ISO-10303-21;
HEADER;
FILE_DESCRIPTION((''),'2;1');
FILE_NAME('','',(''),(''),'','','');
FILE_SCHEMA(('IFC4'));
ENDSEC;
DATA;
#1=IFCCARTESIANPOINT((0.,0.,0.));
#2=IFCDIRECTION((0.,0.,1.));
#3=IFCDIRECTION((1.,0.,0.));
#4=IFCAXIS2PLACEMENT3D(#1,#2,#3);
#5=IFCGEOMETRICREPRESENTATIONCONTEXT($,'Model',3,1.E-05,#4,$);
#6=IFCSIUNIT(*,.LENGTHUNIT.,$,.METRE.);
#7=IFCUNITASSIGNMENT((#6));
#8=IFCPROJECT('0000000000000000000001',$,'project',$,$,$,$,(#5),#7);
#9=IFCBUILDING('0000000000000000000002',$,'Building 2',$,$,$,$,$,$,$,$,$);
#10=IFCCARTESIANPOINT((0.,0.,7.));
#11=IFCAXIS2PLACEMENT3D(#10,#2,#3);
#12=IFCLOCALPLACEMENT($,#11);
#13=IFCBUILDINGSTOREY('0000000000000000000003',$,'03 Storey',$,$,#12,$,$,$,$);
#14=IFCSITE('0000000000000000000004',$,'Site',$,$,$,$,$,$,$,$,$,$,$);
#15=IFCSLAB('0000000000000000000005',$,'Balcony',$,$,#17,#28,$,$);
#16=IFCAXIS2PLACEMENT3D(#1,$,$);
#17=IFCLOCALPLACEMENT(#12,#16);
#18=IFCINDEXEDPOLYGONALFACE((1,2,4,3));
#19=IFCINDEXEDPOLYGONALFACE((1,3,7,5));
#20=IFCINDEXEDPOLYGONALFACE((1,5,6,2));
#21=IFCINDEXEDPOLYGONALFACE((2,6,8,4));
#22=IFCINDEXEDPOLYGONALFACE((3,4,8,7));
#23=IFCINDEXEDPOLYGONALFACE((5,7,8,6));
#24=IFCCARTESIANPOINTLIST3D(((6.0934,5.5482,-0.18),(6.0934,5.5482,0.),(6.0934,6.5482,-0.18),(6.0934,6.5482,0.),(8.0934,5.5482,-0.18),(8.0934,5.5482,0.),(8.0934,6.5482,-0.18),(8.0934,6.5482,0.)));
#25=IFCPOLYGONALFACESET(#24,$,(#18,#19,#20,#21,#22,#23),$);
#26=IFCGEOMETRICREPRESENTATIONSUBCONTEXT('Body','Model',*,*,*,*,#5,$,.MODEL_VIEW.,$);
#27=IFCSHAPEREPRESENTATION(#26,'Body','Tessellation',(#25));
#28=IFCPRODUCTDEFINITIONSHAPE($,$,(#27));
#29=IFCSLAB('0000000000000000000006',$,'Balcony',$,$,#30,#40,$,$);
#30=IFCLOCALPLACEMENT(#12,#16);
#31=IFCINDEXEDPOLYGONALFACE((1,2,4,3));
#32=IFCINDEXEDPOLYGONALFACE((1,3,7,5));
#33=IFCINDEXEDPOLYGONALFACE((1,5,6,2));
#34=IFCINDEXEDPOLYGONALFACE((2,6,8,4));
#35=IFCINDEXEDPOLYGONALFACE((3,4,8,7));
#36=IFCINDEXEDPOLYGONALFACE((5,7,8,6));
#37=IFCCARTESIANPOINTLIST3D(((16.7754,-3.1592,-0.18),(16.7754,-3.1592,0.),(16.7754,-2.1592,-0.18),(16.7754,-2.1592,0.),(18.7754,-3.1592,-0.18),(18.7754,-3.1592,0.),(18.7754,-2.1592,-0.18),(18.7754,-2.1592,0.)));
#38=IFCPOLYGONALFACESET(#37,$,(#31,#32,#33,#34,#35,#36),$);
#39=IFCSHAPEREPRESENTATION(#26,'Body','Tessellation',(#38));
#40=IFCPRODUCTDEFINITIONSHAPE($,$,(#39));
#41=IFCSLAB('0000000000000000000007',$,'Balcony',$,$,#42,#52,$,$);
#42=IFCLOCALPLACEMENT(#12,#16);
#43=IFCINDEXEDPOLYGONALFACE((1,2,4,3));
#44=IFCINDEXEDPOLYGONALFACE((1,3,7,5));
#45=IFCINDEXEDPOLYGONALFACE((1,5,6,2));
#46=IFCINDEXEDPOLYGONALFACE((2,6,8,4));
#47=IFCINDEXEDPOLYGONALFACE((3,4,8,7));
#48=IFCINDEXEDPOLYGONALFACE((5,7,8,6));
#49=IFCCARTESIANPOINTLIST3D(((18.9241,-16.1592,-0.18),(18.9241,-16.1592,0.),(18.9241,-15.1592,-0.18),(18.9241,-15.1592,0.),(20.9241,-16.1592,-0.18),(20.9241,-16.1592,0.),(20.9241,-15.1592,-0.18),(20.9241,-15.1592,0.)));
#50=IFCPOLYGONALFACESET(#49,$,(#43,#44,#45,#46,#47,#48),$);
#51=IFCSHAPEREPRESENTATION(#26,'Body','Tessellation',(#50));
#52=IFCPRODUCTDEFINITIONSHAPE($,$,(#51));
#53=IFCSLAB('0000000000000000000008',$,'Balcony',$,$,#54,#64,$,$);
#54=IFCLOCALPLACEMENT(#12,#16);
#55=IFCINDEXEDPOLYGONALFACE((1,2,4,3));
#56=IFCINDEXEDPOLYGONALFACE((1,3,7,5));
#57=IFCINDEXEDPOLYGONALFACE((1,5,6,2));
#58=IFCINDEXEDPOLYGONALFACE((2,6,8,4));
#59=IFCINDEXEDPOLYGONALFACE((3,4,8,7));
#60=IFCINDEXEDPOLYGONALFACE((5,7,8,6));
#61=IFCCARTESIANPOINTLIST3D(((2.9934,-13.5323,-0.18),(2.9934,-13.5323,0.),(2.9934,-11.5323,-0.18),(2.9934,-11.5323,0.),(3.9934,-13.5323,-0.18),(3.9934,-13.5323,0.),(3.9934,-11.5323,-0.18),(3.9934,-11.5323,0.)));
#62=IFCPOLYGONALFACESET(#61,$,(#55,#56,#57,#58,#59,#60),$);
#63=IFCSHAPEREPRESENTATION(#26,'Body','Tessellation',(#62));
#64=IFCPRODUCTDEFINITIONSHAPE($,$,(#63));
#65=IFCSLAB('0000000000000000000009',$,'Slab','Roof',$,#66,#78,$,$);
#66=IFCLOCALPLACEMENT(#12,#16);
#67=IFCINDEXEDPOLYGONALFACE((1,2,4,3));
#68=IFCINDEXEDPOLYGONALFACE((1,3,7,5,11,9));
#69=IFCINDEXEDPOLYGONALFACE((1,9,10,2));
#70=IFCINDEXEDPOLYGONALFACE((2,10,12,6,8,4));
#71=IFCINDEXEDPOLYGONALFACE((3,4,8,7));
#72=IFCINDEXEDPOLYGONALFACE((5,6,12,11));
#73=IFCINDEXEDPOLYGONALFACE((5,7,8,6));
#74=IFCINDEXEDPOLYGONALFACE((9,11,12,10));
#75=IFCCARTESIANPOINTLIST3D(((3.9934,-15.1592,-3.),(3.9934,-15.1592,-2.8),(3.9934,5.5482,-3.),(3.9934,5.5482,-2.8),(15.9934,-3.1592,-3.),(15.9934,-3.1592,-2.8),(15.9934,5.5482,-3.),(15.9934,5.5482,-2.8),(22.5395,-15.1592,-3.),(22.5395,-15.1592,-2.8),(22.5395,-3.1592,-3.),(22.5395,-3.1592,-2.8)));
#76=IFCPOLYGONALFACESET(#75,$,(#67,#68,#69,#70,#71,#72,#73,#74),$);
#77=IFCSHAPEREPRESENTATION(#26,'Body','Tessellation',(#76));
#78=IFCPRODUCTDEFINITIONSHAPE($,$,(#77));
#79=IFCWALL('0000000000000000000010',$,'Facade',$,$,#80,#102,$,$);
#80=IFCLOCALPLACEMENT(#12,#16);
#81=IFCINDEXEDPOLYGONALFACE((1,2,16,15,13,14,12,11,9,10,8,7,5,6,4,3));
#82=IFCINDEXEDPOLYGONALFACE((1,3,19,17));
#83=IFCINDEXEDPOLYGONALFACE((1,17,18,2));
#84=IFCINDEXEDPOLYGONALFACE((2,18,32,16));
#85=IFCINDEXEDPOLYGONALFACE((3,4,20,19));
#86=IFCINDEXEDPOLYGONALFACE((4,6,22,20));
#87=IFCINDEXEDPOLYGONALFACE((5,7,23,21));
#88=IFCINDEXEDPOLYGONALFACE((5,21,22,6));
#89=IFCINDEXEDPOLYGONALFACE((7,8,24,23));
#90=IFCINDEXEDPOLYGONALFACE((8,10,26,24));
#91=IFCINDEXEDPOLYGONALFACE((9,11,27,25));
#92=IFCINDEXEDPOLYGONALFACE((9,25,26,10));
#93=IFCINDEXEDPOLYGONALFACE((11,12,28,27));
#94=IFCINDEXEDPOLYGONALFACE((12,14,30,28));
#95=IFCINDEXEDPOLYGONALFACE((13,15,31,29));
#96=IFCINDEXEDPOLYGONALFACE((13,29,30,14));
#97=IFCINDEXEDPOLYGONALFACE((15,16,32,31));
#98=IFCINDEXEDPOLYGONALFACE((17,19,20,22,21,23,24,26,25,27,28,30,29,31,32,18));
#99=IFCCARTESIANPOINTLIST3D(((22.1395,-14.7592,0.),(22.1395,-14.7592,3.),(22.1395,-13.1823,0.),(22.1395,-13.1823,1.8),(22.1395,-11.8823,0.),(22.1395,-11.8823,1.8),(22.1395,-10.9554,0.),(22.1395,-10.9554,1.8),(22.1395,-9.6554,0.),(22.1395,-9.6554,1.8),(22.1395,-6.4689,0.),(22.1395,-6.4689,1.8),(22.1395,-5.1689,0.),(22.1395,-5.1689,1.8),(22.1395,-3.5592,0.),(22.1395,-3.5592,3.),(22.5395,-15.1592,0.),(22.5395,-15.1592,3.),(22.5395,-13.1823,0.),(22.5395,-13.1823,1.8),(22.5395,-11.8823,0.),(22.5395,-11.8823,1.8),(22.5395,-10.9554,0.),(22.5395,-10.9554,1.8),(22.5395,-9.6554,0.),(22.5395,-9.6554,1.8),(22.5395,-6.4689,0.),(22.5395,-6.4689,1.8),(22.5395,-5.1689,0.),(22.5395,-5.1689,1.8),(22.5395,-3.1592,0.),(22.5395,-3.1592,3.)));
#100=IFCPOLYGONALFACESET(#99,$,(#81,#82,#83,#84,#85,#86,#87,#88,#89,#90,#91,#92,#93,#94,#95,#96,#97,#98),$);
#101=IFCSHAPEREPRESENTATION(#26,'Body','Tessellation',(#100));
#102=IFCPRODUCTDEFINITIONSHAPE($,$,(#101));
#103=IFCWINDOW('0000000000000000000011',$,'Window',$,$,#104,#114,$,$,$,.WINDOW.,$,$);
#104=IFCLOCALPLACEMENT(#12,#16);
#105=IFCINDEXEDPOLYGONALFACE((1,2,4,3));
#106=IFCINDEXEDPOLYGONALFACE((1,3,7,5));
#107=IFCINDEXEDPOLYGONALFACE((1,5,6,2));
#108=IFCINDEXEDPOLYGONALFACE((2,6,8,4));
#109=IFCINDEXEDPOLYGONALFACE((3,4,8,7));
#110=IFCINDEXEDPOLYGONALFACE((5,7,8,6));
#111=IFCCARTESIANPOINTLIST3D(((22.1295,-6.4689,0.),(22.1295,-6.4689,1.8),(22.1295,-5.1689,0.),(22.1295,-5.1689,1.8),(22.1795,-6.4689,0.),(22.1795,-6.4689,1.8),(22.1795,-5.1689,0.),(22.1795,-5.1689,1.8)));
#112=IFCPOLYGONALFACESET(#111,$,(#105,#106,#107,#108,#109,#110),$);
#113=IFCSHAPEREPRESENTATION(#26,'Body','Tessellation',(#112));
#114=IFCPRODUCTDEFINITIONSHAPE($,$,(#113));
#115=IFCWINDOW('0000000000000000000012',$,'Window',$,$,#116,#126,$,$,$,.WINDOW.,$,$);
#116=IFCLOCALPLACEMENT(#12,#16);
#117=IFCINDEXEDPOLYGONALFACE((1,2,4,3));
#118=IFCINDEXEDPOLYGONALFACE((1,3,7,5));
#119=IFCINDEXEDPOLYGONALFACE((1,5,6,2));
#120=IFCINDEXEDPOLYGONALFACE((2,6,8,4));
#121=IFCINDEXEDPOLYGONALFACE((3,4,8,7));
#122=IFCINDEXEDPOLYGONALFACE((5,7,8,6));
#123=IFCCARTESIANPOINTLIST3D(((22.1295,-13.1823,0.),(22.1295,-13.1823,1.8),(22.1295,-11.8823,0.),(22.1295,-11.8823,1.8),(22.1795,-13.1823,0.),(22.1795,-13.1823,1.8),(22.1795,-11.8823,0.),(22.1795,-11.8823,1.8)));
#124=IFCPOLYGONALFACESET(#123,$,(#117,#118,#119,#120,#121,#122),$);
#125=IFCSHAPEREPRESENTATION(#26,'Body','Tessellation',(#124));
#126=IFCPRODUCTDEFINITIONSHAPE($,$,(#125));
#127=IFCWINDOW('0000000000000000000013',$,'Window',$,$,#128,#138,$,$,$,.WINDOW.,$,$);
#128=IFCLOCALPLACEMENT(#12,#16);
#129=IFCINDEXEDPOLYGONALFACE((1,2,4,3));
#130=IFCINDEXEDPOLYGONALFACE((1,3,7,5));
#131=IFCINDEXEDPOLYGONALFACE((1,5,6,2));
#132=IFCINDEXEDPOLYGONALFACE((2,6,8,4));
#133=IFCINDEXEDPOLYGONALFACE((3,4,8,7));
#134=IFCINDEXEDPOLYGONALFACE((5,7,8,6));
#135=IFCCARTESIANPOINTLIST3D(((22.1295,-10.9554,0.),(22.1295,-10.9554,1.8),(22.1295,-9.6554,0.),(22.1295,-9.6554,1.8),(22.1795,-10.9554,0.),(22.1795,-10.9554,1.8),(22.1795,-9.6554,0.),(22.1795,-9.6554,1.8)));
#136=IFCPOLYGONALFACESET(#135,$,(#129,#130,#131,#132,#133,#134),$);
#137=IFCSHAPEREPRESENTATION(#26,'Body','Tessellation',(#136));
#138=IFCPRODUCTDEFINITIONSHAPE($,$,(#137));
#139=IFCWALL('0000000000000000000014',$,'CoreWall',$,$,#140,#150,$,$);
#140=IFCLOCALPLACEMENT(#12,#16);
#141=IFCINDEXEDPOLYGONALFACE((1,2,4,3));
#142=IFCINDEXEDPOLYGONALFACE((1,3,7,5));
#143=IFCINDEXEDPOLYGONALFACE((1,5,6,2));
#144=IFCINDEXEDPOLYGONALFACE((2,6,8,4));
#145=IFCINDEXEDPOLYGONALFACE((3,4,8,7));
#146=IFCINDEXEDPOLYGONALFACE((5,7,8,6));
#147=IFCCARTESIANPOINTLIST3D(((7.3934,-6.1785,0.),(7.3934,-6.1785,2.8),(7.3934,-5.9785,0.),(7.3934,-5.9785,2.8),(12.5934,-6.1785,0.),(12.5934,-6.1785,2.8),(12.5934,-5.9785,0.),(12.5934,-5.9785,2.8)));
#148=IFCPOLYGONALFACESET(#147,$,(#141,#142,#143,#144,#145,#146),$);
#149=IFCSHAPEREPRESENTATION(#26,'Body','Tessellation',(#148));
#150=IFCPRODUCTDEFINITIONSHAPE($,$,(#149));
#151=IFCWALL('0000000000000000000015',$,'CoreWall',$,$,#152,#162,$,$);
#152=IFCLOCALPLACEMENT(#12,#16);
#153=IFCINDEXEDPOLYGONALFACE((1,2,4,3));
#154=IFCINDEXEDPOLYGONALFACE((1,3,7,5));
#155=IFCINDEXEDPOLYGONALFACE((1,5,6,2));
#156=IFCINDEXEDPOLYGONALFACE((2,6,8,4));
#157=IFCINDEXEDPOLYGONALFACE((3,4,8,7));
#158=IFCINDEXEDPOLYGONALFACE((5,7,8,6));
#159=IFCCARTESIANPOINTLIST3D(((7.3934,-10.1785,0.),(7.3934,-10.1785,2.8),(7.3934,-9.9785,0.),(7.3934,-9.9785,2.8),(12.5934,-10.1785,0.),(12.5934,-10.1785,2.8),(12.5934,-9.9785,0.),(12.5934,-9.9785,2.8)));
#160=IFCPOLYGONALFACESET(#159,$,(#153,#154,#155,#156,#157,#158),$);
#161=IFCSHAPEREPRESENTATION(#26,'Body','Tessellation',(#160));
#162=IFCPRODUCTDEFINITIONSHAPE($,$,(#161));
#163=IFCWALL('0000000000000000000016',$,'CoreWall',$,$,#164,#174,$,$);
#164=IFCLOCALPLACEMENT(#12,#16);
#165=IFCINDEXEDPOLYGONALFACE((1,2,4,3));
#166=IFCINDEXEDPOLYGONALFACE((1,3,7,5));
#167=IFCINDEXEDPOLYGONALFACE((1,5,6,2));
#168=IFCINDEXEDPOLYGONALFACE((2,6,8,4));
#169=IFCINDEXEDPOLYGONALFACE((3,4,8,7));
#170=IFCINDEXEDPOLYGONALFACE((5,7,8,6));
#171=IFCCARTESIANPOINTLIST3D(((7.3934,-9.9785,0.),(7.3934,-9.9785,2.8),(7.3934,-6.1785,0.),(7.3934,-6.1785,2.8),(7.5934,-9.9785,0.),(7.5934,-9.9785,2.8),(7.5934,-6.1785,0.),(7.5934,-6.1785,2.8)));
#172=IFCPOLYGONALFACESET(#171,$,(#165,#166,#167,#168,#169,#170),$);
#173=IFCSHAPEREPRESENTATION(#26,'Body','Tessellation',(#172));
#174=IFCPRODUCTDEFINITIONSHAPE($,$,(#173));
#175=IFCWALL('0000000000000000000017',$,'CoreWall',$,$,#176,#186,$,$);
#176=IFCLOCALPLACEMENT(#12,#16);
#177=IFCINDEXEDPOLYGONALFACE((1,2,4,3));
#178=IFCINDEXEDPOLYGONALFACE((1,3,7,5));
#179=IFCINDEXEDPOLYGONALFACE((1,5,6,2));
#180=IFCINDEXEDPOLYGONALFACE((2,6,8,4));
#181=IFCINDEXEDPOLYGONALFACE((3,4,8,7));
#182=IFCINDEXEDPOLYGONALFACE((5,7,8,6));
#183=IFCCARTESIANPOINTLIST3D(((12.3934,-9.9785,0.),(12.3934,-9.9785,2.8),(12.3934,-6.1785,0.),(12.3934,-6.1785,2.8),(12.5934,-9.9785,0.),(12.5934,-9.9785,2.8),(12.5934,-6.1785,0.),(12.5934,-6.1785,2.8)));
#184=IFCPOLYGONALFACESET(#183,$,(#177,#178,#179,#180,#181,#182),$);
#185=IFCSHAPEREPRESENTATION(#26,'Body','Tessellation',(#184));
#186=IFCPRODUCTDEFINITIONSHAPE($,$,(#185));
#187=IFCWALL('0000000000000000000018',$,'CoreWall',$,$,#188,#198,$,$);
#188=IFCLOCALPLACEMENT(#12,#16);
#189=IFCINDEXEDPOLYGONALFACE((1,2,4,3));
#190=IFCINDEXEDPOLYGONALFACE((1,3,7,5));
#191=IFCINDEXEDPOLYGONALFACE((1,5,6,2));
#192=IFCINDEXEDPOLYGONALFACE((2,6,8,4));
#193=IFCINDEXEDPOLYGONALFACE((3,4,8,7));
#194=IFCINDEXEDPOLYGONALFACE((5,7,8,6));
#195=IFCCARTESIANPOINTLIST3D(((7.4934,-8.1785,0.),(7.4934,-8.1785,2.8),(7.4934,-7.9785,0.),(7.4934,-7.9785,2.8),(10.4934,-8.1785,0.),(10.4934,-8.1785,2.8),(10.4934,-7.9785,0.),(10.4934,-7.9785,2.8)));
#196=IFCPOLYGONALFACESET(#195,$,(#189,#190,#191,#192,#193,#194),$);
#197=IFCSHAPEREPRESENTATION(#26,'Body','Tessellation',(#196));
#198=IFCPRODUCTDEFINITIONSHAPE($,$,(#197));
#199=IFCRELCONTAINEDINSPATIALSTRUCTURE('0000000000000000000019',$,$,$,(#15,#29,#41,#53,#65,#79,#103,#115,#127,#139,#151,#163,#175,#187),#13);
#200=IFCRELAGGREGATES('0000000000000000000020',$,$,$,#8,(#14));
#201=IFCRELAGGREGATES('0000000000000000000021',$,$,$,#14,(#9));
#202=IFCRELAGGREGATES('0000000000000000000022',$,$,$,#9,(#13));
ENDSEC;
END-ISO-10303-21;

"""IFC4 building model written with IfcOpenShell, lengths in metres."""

from ifc_helpers import new_model, si_unit, frame, origin_with_axes, place, context, subcontext, project, spatial, polyline, line, indexed_curve, outline, extrude, element, fill, save


model = new_model("IFC4")

# Units and contexts
model_context = context("Model", 3, precision=1e-05, world=origin_with_axes())
body_context = subcontext(model_context, "Body", "Model", "MODEL_VIEW")
ifc_project = project(units=[si_unit("LENGTHUNIT", "METRE")], contexts=[model_context])

# Site, building, storey
site = spatial("IfcSite", under=ifc_project, Name="Site")
building = spatial("IfcBuilding", under=site, Name="Building 2")
storey_placement = place(None, frame((0.0, 0.0, 7.0), z_axis=(0.0, 0.0, 1.0), x_axis=(1.0, 0.0, 0.0)))
storey = spatial("IfcBuildingStorey", under=building, at=storey_placement, Name="03 Storey")

# Slabs
slab_1_placement = place(storey_placement, origin_with_axes())
element("IfcSlab", 1, at=slab_1_placement, inside=storey, Name="Balcony", context=body_context, shape_type="SweptSolid", body=[
    extrude(outline(indexed_curve([(6.0934, 5.5482), (6.0934, 6.5482), (8.0934, 6.5482), (8.0934, 5.5482)], segments=[line(1, 2), line(2, 3), line(3, 4)])), origin_with_axes(), (0.0, 0.0, -1.0), 0.18),
])
slab_2_placement = place(storey_placement, origin_with_axes())
element("IfcSlab", 2, at=slab_2_placement, inside=storey, Name="Balcony", context=body_context, shape_type="SweptSolid", body=[
    extrude(outline(indexed_curve([(16.7754, -3.1592), (16.7754, -2.1592), (18.7754, -2.1592), (18.7754, -3.1592)], segments=[line(1, 2), line(2, 3), line(3, 4)])), origin_with_axes(), (0.0, 0.0, -1.0), 0.18),
])
slab_3_placement = place(storey_placement, origin_with_axes())
element("IfcSlab", 3, at=slab_3_placement, inside=storey, Name="Balcony", context=body_context, shape_type="SweptSolid", body=[
    extrude(outline(indexed_curve([(20.9241, -15.1592), (20.9241, -16.1592), (18.9241, -16.1592), (18.9241, -15.1592)], segments=[line(1, 2), line(2, 3), line(3, 4)])), origin_with_axes(), (0.0, 0.0, -1.0), 0.18),
])
slab_4_placement = place(storey_placement, origin_with_axes())
element("IfcSlab", 4, at=slab_4_placement, inside=storey, Name="Balcony", context=body_context, shape_type="SweptSolid", body=[
    extrude(outline(indexed_curve([(3.9934, -13.5323), (2.9934, -13.5323), (2.9934, -11.5323), (3.9934, -11.5323)], segments=[line(1, 2), line(2, 3), line(3, 4)])), origin_with_axes(), (0.0, 0.0, -1.0), 0.18),
])
slab_5_placement = place(storey_placement, frame((22.5395, -3.1592, 0.0), z_axis=(0.0, 0.0, -1.0), x_axis=(-1.0, 0.0, 0.0)))
element("IfcSlab", 5, at=slab_5_placement, inside=storey, Name="Slab", Description="Roof", context=body_context, shape_type="SweptSolid", body=[
    extrude(outline(polyline([(0.0, 0.0), (6.5461, 0.0), (6.5461, 8.7074), (18.5461, 8.7074), (18.5461, -12.0), (0.0, -12.0), (0.0, 0.0)])), frame((0.0, 0.0, 3.0), z_axis=(0.0, 0.0, 1.0), x_axis=(1.0, 0.0, 0.0)), (0.0, 0.0, -1.0), 0.2),
])

# Wall, openings, windows
wall_1_placement = place(storey_placement, origin_with_axes())
wall_1 = element("IfcWall", 6, at=wall_1_placement, inside=storey, Name="Facade", context=body_context, shape_type="SweptSolid", body=[
    extrude(outline(indexed_curve([(22.1395, -14.7592), (22.1395, -3.5592), (22.5395, -3.1592), (22.5395, -15.1592)], segments=[line(1, 2), line(2, 3), line(3, 4)])), origin_with_axes(), (0.0, 0.0, 1.0), 3.0),
])
opening_1_placement = place(wall_1_placement, origin_with_axes())
opening_1 = element("IfcOpeningElement", 7, at=opening_1_placement, cuts=wall_1, context=body_context, shape_type="SweptSolid", body=[
    extrude(outline(indexed_curve([(22.5795, -6.4689), (22.0795, -6.4689), (22.0795, -5.1689), (22.5795, -5.1689)], segments=[line(1, 2), line(2, 3), line(3, 4)])), origin_with_axes(), (0.0, 0.0, 1.0), 1.8),
])
opening_2_placement = place(wall_1_placement, origin_with_axes())
opening_2 = element("IfcOpeningElement", 8, at=opening_2_placement, cuts=wall_1, context=body_context, shape_type="SweptSolid", body=[
    extrude(outline(indexed_curve([(22.5795, -13.1823), (22.0795, -13.1823), (22.0795, -11.8823), (22.5795, -11.8823)], segments=[line(1, 2), line(2, 3), line(3, 4)])), origin_with_axes(), (0.0, 0.0, 1.0), 1.8),
])
opening_3_placement = place(wall_1_placement, origin_with_axes())
opening_3 = element("IfcOpeningElement", 9, at=opening_3_placement, cuts=wall_1, context=body_context, shape_type="SweptSolid", body=[
    extrude(outline(indexed_curve([(22.5795, -10.9554), (22.0795, -10.9554), (22.0795, -9.6554), (22.5795, -9.6554)], segments=[line(1, 2), line(2, 3), line(3, 4)])), origin_with_axes(), (0.0, 0.0, 1.0), 1.8),
])
window_1_placement = place(storey_placement, origin_with_axes())
window_1 = element("IfcWindow", 10, at=window_1_placement, inside=storey, Name="Window", PredefinedType="WINDOW", context=body_context, shape_type="SweptSolid", body=[
    extrude(outline(indexed_curve([(22.1795, -6.4689), (22.1295, -6.4689), (22.1295, -5.1689), (22.1795, -5.1689)], segments=[line(1, 2), line(2, 3), line(3, 4)])), origin_with_axes(), (0.0, 0.0, 1.0), 1.8),
])
fill(opening_1, window_1)
window_2_placement = place(storey_placement, origin_with_axes())
window_2 = element("IfcWindow", 11, at=window_2_placement, inside=storey, Name="Window", PredefinedType="WINDOW", context=body_context, shape_type="SweptSolid", body=[
    extrude(outline(indexed_curve([(22.1795, -13.1823), (22.1295, -13.1823), (22.1295, -11.8823), (22.1795, -11.8823)], segments=[line(1, 2), line(2, 3), line(3, 4)])), origin_with_axes(), (0.0, 0.0, 1.0), 1.8),
])
fill(opening_2, window_2)
window_3_placement = place(storey_placement, origin_with_axes())
window_3 = element("IfcWindow", 12, at=window_3_placement, inside=storey, Name="Window", PredefinedType="WINDOW", context=body_context, shape_type="SweptSolid", body=[
    extrude(outline(indexed_curve([(22.1795, -10.9554), (22.1295, -10.9554), (22.1295, -9.6554), (22.1795, -9.6554)], segments=[line(1, 2), line(2, 3), line(3, 4)])), origin_with_axes(), (0.0, 0.0, 1.0), 1.8),
])
fill(opening_3, window_3)

# Walls
wall_2_placement = place(storey_placement, origin_with_axes())
element("IfcWall", 13, at=wall_2_placement, inside=storey, Name="CoreWall", context=body_context, shape_type="SweptSolid", body=[
    extrude(outline(indexed_curve([(12.5934, -5.9785), (7.3934, -5.9785), (7.3934, -6.1785), (12.5934, -6.1785)], segments=[line(1, 2), line(2, 3), line(3, 4)])), origin_with_axes(), (0.0, 0.0, 1.0), 2.8),
])
wall_3_placement = place(storey_placement, origin_with_axes())
element("IfcWall", 14, at=wall_3_placement, inside=storey, Name="CoreWall", context=body_context, shape_type="SweptSolid", body=[
    extrude(outline(indexed_curve([(7.3934, -10.1785), (12.5934, -10.1785), (12.5934, -9.9785), (7.3934, -9.9785)], segments=[line(1, 2), line(2, 3), line(3, 4)])), origin_with_axes(), (0.0, 0.0, 1.0), 2.8),
])
wall_4_placement = place(storey_placement, origin_with_axes())
element("IfcWall", 15, at=wall_4_placement, inside=storey, Name="CoreWall", context=body_context, shape_type="SweptSolid", body=[
    extrude(outline(indexed_curve([(7.5934, -9.9785), (7.5934, -6.1785), (7.3934, -6.1785), (7.3934, -9.9785)], segments=[line(1, 2), line(2, 3), line(3, 4)])), origin_with_axes(), (0.0, 0.0, 1.0), 2.8),
])
wall_5_placement = place(storey_placement, origin_with_axes())
element("IfcWall", 16, at=wall_5_placement, inside=storey, Name="CoreWall", context=body_context, shape_type="SweptSolid", body=[
    extrude(outline(indexed_curve([(12.3934, -6.1785), (12.3934, -9.9785), (12.5934, -9.9785), (12.5934, -6.1785)], segments=[line(1, 2), line(2, 3), line(3, 4)])), origin_with_axes(), (0.0, 0.0, 1.0), 2.8),
])
wall_6_placement = place(storey_placement, origin_with_axes())
element("IfcWall", 17, at=wall_6_placement, inside=storey, Name="CoreWall", context=body_context, shape_type="SweptSolid", body=[
    extrude(outline(indexed_curve([(10.4934, -7.9785), (7.4934, -7.9785), (7.4934, -8.1785), (10.4934, -8.1785)], segments=[line(1, 2), line(2, 3), line(3, 4)])), origin_with_axes(), (0.0, 0.0, 1.0), 2.8),
])

save(model, "model.ifc")
